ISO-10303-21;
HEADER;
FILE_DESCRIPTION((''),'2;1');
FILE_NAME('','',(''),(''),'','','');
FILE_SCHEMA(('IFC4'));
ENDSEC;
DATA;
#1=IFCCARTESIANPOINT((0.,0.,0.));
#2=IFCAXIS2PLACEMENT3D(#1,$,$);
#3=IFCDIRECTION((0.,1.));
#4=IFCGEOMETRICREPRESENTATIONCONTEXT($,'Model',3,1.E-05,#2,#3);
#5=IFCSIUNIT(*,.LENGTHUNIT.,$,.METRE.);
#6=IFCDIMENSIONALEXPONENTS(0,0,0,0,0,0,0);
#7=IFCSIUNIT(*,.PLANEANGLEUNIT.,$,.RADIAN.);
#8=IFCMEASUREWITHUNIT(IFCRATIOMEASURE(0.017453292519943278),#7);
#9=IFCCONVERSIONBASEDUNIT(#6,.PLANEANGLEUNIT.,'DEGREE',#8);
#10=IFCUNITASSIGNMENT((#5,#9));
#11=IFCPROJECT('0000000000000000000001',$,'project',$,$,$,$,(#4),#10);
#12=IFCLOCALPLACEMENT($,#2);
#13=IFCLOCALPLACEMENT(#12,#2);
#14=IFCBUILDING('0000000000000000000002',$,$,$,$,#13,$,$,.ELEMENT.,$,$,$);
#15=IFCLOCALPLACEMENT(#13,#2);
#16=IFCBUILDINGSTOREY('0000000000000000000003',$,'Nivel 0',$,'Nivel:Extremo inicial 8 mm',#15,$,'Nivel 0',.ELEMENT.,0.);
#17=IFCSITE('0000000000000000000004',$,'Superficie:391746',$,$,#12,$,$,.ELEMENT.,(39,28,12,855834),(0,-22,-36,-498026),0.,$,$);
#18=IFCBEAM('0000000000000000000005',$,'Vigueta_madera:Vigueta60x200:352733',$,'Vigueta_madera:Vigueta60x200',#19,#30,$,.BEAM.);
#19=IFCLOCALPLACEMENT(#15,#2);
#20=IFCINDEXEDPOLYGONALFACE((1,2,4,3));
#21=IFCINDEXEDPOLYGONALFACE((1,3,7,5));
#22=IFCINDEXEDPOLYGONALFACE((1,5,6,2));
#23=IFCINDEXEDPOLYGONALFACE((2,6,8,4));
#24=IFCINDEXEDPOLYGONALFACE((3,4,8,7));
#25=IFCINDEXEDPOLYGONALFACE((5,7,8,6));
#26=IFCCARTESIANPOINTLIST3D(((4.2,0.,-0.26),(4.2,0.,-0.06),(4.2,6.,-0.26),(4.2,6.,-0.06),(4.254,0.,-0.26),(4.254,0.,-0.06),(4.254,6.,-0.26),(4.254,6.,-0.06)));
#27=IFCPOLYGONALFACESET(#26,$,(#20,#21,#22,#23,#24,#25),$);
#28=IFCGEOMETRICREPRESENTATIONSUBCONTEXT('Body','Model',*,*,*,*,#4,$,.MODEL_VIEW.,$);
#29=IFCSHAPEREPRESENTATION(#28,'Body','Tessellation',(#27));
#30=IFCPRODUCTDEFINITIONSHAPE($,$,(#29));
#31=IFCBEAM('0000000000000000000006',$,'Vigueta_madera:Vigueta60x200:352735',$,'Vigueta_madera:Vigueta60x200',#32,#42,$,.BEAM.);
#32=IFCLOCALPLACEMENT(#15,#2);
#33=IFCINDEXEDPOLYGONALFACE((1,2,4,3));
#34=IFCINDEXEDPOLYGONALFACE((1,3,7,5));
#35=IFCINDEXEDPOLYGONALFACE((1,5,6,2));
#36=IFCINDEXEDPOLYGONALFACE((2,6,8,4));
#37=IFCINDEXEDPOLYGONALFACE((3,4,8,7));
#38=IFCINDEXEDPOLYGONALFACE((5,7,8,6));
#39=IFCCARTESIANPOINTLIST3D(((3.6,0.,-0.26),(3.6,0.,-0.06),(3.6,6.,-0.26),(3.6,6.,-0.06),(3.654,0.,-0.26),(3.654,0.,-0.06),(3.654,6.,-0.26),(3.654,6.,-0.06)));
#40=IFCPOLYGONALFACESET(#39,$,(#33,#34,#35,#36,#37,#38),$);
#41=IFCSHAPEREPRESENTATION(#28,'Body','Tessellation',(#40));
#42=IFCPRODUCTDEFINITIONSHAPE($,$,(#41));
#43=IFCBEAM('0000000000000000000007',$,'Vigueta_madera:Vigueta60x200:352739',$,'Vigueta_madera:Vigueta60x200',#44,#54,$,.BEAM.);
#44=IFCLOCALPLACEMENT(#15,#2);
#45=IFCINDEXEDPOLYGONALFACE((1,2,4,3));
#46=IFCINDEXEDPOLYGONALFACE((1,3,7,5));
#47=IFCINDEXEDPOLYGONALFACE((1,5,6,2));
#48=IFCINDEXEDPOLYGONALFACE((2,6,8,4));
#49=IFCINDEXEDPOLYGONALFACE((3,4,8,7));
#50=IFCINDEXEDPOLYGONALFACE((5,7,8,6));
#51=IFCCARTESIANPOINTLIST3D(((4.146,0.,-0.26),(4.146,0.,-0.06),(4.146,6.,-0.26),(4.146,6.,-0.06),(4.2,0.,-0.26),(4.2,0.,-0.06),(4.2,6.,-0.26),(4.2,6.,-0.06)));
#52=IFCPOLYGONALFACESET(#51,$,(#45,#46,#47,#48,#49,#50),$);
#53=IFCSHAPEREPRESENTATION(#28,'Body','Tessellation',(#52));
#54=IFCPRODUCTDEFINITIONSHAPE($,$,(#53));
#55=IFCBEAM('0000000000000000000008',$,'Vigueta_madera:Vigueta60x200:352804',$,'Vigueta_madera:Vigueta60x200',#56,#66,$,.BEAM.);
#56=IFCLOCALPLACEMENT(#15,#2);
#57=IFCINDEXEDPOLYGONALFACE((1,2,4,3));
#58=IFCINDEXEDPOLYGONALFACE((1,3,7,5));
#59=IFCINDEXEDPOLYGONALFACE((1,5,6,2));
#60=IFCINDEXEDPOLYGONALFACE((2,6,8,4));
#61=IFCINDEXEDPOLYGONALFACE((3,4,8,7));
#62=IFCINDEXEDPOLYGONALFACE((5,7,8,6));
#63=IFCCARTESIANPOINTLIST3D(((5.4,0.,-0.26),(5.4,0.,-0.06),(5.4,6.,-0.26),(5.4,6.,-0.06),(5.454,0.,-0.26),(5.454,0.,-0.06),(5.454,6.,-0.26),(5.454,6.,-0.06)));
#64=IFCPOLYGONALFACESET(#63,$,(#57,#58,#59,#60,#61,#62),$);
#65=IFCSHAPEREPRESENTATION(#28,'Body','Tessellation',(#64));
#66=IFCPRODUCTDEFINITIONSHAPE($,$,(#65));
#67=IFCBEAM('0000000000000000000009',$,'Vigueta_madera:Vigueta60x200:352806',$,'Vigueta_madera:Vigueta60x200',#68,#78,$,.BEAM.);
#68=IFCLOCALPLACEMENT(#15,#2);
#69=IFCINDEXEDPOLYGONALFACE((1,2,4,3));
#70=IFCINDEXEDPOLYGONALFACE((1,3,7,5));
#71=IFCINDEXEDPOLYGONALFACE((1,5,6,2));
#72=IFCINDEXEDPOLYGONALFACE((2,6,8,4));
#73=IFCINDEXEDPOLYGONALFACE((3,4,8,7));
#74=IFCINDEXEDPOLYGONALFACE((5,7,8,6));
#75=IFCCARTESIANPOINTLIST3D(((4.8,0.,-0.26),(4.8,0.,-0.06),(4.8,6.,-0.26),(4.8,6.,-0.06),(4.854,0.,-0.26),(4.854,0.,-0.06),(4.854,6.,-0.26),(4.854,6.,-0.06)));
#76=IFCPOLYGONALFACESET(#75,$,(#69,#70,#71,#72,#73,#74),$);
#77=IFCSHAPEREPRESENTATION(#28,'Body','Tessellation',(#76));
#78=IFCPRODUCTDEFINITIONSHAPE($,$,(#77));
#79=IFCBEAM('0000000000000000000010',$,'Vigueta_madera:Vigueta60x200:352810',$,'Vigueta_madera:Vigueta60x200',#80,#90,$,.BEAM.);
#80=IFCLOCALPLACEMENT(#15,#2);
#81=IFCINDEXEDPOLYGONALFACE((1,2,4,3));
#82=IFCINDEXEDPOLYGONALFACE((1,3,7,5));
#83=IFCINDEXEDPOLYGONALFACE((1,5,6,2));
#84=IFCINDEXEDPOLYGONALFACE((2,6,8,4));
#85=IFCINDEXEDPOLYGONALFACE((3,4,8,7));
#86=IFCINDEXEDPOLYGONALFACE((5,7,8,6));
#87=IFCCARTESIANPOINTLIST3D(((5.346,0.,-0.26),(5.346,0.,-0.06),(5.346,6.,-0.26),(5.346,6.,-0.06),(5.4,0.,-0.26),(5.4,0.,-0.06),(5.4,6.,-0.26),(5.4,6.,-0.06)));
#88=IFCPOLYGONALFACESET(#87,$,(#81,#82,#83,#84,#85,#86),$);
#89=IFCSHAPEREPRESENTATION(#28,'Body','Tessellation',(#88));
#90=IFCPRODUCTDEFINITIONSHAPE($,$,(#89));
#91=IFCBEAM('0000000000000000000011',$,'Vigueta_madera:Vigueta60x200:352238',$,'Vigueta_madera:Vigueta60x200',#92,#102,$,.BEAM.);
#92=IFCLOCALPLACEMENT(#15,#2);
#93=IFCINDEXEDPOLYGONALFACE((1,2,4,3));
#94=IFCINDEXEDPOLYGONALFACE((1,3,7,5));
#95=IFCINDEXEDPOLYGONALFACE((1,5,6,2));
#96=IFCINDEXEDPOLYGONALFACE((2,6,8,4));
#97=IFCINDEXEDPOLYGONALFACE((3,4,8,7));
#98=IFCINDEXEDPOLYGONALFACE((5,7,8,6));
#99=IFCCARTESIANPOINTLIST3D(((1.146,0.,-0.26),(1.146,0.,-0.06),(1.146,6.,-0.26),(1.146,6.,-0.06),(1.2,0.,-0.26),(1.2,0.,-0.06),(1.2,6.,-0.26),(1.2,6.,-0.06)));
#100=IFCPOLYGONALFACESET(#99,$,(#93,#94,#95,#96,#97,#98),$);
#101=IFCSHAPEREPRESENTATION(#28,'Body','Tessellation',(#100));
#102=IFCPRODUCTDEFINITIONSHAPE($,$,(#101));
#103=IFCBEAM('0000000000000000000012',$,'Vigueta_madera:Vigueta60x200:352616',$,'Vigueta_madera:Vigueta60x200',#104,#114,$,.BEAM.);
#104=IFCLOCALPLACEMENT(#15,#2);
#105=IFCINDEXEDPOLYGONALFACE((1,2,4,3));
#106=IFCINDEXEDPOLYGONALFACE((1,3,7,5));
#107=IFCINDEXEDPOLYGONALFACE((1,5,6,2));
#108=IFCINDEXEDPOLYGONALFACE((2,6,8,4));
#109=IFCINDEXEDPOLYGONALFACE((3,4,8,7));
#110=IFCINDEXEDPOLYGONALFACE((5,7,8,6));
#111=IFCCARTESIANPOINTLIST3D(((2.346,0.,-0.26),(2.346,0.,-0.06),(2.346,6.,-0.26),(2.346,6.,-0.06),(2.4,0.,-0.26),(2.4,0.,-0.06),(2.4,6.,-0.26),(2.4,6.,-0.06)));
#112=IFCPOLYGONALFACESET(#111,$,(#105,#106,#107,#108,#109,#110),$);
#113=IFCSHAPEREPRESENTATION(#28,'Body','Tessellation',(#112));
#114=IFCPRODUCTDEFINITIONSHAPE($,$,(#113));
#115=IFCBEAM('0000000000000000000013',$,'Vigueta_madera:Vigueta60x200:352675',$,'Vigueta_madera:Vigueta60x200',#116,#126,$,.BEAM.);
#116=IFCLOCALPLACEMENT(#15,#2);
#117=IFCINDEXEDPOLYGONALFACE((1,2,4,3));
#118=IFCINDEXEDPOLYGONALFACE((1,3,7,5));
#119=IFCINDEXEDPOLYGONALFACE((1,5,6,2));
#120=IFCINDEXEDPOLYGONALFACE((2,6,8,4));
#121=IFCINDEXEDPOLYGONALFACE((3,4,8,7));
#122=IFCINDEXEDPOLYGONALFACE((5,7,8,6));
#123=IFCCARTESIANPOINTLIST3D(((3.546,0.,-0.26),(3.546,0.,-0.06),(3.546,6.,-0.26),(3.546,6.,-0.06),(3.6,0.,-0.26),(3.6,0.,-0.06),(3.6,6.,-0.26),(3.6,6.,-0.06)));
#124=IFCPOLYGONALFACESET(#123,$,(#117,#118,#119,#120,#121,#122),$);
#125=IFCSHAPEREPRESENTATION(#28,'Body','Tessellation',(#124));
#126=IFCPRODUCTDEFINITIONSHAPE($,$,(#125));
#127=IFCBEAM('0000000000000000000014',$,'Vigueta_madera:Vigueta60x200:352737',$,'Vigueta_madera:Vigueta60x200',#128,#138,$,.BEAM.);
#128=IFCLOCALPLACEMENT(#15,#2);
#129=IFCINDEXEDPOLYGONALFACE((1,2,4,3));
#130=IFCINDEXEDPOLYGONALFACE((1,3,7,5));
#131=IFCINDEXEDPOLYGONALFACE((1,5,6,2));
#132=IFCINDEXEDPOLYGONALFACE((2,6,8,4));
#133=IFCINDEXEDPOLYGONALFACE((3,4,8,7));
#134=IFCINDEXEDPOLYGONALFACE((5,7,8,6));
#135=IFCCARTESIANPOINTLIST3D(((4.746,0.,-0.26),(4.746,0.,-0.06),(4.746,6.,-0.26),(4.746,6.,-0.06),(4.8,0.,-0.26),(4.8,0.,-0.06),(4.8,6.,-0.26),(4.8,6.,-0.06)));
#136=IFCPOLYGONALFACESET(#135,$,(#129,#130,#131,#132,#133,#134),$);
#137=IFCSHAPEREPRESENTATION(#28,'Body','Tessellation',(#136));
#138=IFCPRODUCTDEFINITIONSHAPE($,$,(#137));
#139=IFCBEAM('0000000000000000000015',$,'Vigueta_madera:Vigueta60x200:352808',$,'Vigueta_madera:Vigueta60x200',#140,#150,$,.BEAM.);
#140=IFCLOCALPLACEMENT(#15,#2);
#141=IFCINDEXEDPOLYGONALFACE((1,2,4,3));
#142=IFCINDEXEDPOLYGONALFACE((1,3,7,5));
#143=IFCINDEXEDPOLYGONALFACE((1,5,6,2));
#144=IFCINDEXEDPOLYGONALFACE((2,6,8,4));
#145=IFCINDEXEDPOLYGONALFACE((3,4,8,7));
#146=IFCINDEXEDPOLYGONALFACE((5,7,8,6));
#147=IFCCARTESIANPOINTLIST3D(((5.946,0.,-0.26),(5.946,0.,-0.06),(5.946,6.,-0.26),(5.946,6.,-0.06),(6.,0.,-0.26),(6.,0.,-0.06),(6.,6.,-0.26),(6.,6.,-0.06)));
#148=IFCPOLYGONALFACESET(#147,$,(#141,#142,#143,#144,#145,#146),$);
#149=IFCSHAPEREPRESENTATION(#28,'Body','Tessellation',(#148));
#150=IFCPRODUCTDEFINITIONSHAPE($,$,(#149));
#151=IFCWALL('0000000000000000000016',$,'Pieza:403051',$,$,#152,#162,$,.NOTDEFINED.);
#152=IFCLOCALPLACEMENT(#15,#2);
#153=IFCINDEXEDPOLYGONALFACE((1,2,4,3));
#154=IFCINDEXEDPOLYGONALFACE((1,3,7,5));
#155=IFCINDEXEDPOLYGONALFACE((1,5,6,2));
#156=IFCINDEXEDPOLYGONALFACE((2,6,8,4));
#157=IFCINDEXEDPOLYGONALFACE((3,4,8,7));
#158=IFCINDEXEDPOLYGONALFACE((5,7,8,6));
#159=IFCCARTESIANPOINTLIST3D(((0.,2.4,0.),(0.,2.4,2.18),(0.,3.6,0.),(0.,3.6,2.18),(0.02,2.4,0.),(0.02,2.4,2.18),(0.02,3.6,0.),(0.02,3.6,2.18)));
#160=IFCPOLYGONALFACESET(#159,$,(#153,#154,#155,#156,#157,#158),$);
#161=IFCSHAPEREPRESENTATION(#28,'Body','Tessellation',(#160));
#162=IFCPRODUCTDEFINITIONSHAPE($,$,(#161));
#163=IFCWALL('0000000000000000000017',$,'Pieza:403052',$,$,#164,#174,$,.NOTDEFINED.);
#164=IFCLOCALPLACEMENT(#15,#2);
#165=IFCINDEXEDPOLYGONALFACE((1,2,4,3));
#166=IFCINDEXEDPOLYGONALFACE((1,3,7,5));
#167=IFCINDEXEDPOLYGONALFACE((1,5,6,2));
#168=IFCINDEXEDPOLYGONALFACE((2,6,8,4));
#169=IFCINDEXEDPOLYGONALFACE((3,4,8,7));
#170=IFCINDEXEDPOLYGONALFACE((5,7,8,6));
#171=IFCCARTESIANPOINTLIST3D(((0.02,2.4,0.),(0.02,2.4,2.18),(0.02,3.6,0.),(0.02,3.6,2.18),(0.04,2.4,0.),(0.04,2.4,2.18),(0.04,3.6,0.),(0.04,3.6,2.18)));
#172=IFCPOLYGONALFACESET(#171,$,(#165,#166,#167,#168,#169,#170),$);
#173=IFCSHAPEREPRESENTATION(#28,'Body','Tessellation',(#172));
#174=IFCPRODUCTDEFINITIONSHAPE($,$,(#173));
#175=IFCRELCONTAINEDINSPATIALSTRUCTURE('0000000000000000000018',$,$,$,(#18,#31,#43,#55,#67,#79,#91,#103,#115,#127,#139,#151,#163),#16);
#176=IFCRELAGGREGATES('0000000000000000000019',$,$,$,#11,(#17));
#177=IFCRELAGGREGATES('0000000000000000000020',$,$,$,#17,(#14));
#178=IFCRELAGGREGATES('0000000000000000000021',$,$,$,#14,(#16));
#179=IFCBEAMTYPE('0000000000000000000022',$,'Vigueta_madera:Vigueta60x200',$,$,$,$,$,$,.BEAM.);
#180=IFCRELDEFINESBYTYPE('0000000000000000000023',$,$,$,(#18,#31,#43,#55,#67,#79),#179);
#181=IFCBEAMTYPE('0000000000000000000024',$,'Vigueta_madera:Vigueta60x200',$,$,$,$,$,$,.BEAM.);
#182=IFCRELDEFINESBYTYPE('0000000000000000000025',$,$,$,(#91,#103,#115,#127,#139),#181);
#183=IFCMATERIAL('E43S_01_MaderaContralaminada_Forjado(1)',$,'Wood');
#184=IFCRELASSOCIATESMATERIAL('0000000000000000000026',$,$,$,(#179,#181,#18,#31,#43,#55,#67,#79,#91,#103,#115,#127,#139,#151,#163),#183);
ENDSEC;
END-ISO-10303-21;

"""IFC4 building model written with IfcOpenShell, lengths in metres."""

from ifc_helpers import new_model, entity, si_unit, converted_unit, direction, frame, frame_2d, origin, origin_2d_with_axis, place, context, subcontext, project, spatial, polyline, segment, composite_curve, rectangle, outline, extrude, source, transform, mapped, material, material_profile, profile_set, profile_usage, type_object, type_shapes, element, save


model = new_model("IFC4")

# Units and contexts
model_context = context("Model", 3, precision=1e-05, world=origin(), true_north=direction((0.0, 1.0)))
body_context = subcontext(model_context, "Body", "Model", "MODEL_VIEW")
ifc_project = project(units=[si_unit("LENGTHUNIT", "METRE"), converted_unit("PLANEANGLEUNIT", "DEGREE", entity("IfcRatioMeasure", 0.017453292519943278), si_unit("PLANEANGLEUNIT", "RADIAN"), dimensions=[0, 0, 0, 0, 0, 0, 0])], contexts=[model_context])

# Site, building, storey
site_placement = place(None, origin())
site = spatial("IfcSite", under=ifc_project, at=site_placement, Name="Superficie:391746", CompositionType="ELEMENT", RefLatitude=(39, 28, 12, 855834), RefLongitude=(0, -22, -36, -498026), RefElevation=0.0)
building_placement = place(site_placement, origin())
building = spatial("IfcBuilding", under=site, at=building_placement, CompositionType="ELEMENT")
storey_placement = place(building_placement, origin())
storey = spatial("IfcBuildingStorey", under=building, at=storey_placement, Name="Nivel 0", ObjectType="Nivel:Extremo inicial 8 mm", LongName="Nivel 0", CompositionType="ELEMENT", Elevation=0.0)

# Beams
ifc_material_1 = material(Name="E43S_01_MaderaContralaminada_Forjado(1)", Category="Wood")
ifc_material_profile_1 = material_profile(ifc_material_1, outline(composite_curve([segment(polyline([(-0.027, -0.1, 0.0), (-0.027, 0.1, 0.0)]), True, "CONTINUOUS"), segment(polyline([(-0.027, 0.1, 0.0), (0.027, 0.1, 0.0)]), True, "CONTINUOUS"), segment(polyline([(0.027, 0.1, 0.0), (0.027, -0.1, 0.0)]), True, "CONTINUOUS"), segment(polyline([(0.027, -0.1, 0.0), (-0.027, -0.1, 0.0)]), True, "CONTINUOUS")], self_intersect=False), kind="CURVE"), Name="Vigueta60x200")
ifc_material_profile_2 = material_profile(ifc_material_1, outline(composite_curve([segment(polyline([(3.0, 0.027, 0.1), (3.0, 0.027, -0.1)]), True, "CONTINUOUS"), segment(polyline([(3.0, 0.027, -0.1), (-3.0, 0.027, -0.1)]), True, "CONTINUOUS"), segment(polyline([(-3.0, 0.027, -0.1), (-3.0, 0.027, 0.1)]), True, "CONTINUOUS"), segment(polyline([(-3.0, 0.027, 0.1), (3.0, 0.027, 0.1)]), True, "CONTINUOUS")], self_intersect=False), kind="CURVE"), Name="Vigueta60x200")
ifc_profile_set_1 = profile_set([ifc_material_profile_1, ifc_material_profile_2], Name="Vigueta60x200")
beam_type_1 = type_object("IfcBeamType", Name="Vigueta_madera:Vigueta60x200", PredefinedType="BEAM", material=ifc_profile_set_1)
shared_shape_1 = source(origin(), body_context, "Body", "SweptSolid", [
    extrude(rectangle(XDim=0.2, YDim=0.054, at=origin_2d_with_axis()), frame((-3.0, 0.0, 0.0), z_axis=(1.0, 0.0, 0.0), x_axis=(0.0, 0.0, -1.0)), (0.0, 0.0, 1.0), 6.0),
])
type_shapes(beam_type_1, [shared_shape_1])
ifc_profile_usage_1 = profile_usage(ifc_profile_set_1, cardinal=8)
beam_1_placement = place(storey_placement, frame((4.227, 3.0, -0.16), z_axis=(0.0, 0.0, 1.0), x_axis=(0.0, 1.0, 0.0)))
element("IfcBeam", 1, at=beam_1_placement, inside=storey, type_object=beam_type_1, material=ifc_profile_usage_1, Name="Vigueta_madera:Vigueta60x200:352733", ObjectType="Vigueta_madera:Vigueta60x200", PredefinedType="BEAM", context=body_context, shape_type="MappedRepresentation", body=[
    mapped(shared_shape_1, transform((0.0, 0.0, 0.0), scale=1.0)),
])
ifc_profile_usage_2 = profile_usage(ifc_profile_set_1, cardinal=8)
beam_2_placement = place(storey_placement, frame((3.627, 3.0, -0.16), z_axis=(0.0, 0.0, 1.0), x_axis=(0.0, 1.0, 0.0)))
element("IfcBeam", 2, at=beam_2_placement, inside=storey, type_object=beam_type_1, material=ifc_profile_usage_2, Name="Vigueta_madera:Vigueta60x200:352735", ObjectType="Vigueta_madera:Vigueta60x200", PredefinedType="BEAM", context=body_context, shape_type="MappedRepresentation", body=[
    mapped(shared_shape_1, transform((0.0, 0.0, 0.0), scale=1.0)),
])
ifc_profile_usage_3 = profile_usage(ifc_profile_set_1, cardinal=8)
beam_3_placement = place(storey_placement, frame((4.173, 3.0, -0.16), z_axis=(0.0, 0.0, 1.0), x_axis=(0.0, 1.0, 0.0)))
element("IfcBeam", 3, at=beam_3_placement, inside=storey, type_object=beam_type_1, material=ifc_profile_usage_3, Name="Vigueta_madera:Vigueta60x200:352739", ObjectType="Vigueta_madera:Vigueta60x200", PredefinedType="BEAM", context=body_context, shape_type="MappedRepresentation", body=[
    mapped(shared_shape_1, transform((0.0, 0.0, 0.0), scale=1.0)),
])
ifc_profile_usage_4 = profile_usage(ifc_profile_set_1, cardinal=8)
beam_4_placement = place(storey_placement, frame((5.427, 3.0, -0.16), z_axis=(0.0, 0.0, 1.0), x_axis=(0.0, 1.0, 0.0)))
element("IfcBeam", 4, at=beam_4_placement, inside=storey, type_object=beam_type_1, material=ifc_profile_usage_4, Name="Vigueta_madera:Vigueta60x200:352804", ObjectType="Vigueta_madera:Vigueta60x200", PredefinedType="BEAM", context=body_context, shape_type="MappedRepresentation", body=[
    mapped(shared_shape_1, transform((0.0, 0.0, 0.0), scale=1.0)),
])
ifc_profile_usage_5 = profile_usage(ifc_profile_set_1, cardinal=8)
beam_5_placement = place(storey_placement, frame((4.827, 3.0, -0.16), z_axis=(0.0, 0.0, 1.0), x_axis=(0.0, 1.0, 0.0)))
element("IfcBeam", 5, at=beam_5_placement, inside=storey, type_object=beam_type_1, material=ifc_profile_usage_5, Name="Vigueta_madera:Vigueta60x200:352806", ObjectType="Vigueta_madera:Vigueta60x200", PredefinedType="BEAM", context=body_context, shape_type="MappedRepresentation", body=[
    mapped(shared_shape_1, transform((0.0, 0.0, 0.0), scale=1.0)),
])
ifc_profile_usage_6 = profile_usage(ifc_profile_set_1, cardinal=8)
beam_6_placement = place(storey_placement, frame((5.373, 3.0, -0.16), z_axis=(0.0, 0.0, 1.0), x_axis=(0.0, 1.0, 0.0)))
element("IfcBeam", 6, at=beam_6_placement, inside=storey, type_object=beam_type_1, material=ifc_profile_usage_6, Name="Vigueta_madera:Vigueta60x200:352810", ObjectType="Vigueta_madera:Vigueta60x200", PredefinedType="BEAM", context=body_context, shape_type="MappedRepresentation", body=[
    mapped(shared_shape_1, transform((0.0, 0.0, 0.0), scale=1.0)),
])
ifc_profile_usage_7 = profile_usage(ifc_profile_set_1, cardinal=8)
beam_type_2 = type_object("IfcBeamType", Name="Vigueta_madera:Vigueta60x200", PredefinedType="BEAM", material=ifc_profile_set_1)
shared_shape_2 = source(origin(), body_context, "Body", "SweptSolid", [
    extrude(rectangle(XDim=0.2, YDim=0.054, at=origin_2d_with_axis()), frame((-3.06, 0.0, 0.0), z_axis=(1.0, 0.0, 0.0), x_axis=(0.0, 0.0, -1.0)), (0.0, 0.0, 1.0), 6.0),
])
type_shapes(beam_type_2, [shared_shape_2])
beam_7_placement = place(storey_placement, frame((1.173, 3.06, -0.16), z_axis=(0.0, 0.0, 1.0), x_axis=(0.0, 1.0, 0.0)))
element("IfcBeam", 7, at=beam_7_placement, inside=storey, type_object=beam_type_2, material=ifc_profile_usage_7, Name="Vigueta_madera:Vigueta60x200:352238", ObjectType="Vigueta_madera:Vigueta60x200", PredefinedType="BEAM", context=body_context, shape_type="MappedRepresentation", body=[
    mapped(shared_shape_2, transform((0.0, 0.0, 0.0), scale=1.0)),
])
ifc_profile_usage_8 = profile_usage(ifc_profile_set_1, cardinal=8)
beam_8_placement = place(storey_placement, frame((2.373, 3.06, -0.16), z_axis=(0.0, 0.0, 1.0), x_axis=(0.0, 1.0, 0.0)))
element("IfcBeam", 8, at=beam_8_placement, inside=storey, type_object=beam_type_2, material=ifc_profile_usage_8, Name="Vigueta_madera:Vigueta60x200:352616", ObjectType="Vigueta_madera:Vigueta60x200", PredefinedType="BEAM", context=body_context, shape_type="MappedRepresentation", body=[
    mapped(shared_shape_2, transform((0.0, 0.0, 0.0), scale=1.0)),
])
ifc_profile_usage_9 = profile_usage(ifc_profile_set_1, cardinal=8)
beam_9_placement = place(storey_placement, frame((3.573, 3.06, -0.16), z_axis=(0.0, 0.0, 1.0), x_axis=(0.0, 1.0, 0.0)))
element("IfcBeam", 9, at=beam_9_placement, inside=storey, type_object=beam_type_2, material=ifc_profile_usage_9, Name="Vigueta_madera:Vigueta60x200:352675", ObjectType="Vigueta_madera:Vigueta60x200", PredefinedType="BEAM", context=body_context, shape_type="MappedRepresentation", body=[
    mapped(shared_shape_2, transform((0.0, 0.0, 0.0), scale=1.0)),
])
ifc_profile_usage_10 = profile_usage(ifc_profile_set_1, cardinal=8)
beam_10_placement = place(storey_placement, frame((4.773, 3.06, -0.16), z_axis=(0.0, 0.0, 1.0), x_axis=(0.0, 1.0, 0.0)))
element("IfcBeam", 10, at=beam_10_placement, inside=storey, type_object=beam_type_2, material=ifc_profile_usage_10, Name="Vigueta_madera:Vigueta60x200:352737", ObjectType="Vigueta_madera:Vigueta60x200", PredefinedType="BEAM", context=body_context, shape_type="MappedRepresentation", body=[
    mapped(shared_shape_2, transform((0.0, 0.0, 0.0), scale=1.0)),
])
ifc_profile_usage_11 = profile_usage(ifc_profile_set_1, cardinal=8)
beam_11_placement = place(storey_placement, frame((5.973, 3.06, -0.16), z_axis=(0.0, 0.0, 1.0), x_axis=(0.0, 1.0, 0.0)))
element("IfcBeam", 11, at=beam_11_placement, inside=storey, type_object=beam_type_2, material=ifc_profile_usage_11, Name="Vigueta_madera:Vigueta60x200:352808", ObjectType="Vigueta_madera:Vigueta60x200", PredefinedType="BEAM", context=body_context, shape_type="MappedRepresentation", body=[
    mapped(shared_shape_2, transform((0.0, 0.0, 0.0), scale=1.0)),
])

# Walls
wall_1_placement = place(storey_placement, frame((0.0, 2.4, 0.0)))
element("IfcWall", 12, at=wall_1_placement, inside=storey, material=ifc_material_1, Name="Pieza:403051", PredefinedType="NOTDEFINED", context=body_context, shape_type="SweptSolid", body=[
    extrude(rectangle(XDim=1.2, YDim=0.02, at=frame_2d((0.0, 0.0), x_axis=(1.0, 0.0))), frame((0.01, 0.6, 0.0), z_axis=(0.0, 0.0, 1.0), x_axis=(0.0, -1.0, 0.0)), (0.0, 0.0, 1.0), 2.18),
])
wall_2_placement = place(storey_placement, frame((0.02, 2.4, 0.0)))
element("IfcWall", 13, at=wall_2_placement, inside=storey, material=ifc_material_1, Name="Pieza:403052", PredefinedType="NOTDEFINED", context=body_context, shape_type="SweptSolid", body=[
    extrude(rectangle(XDim=1.2, YDim=0.02, at=frame_2d((0.0, 0.0), x_axis=(1.0, 0.0))), frame((0.01, 0.6, 0.0), z_axis=(0.0, 0.0, 1.0), x_axis=(0.0, -1.0, 0.0)), (0.0, 0.0, 1.0), 2.18),
])

save(model, "model.ifc")
